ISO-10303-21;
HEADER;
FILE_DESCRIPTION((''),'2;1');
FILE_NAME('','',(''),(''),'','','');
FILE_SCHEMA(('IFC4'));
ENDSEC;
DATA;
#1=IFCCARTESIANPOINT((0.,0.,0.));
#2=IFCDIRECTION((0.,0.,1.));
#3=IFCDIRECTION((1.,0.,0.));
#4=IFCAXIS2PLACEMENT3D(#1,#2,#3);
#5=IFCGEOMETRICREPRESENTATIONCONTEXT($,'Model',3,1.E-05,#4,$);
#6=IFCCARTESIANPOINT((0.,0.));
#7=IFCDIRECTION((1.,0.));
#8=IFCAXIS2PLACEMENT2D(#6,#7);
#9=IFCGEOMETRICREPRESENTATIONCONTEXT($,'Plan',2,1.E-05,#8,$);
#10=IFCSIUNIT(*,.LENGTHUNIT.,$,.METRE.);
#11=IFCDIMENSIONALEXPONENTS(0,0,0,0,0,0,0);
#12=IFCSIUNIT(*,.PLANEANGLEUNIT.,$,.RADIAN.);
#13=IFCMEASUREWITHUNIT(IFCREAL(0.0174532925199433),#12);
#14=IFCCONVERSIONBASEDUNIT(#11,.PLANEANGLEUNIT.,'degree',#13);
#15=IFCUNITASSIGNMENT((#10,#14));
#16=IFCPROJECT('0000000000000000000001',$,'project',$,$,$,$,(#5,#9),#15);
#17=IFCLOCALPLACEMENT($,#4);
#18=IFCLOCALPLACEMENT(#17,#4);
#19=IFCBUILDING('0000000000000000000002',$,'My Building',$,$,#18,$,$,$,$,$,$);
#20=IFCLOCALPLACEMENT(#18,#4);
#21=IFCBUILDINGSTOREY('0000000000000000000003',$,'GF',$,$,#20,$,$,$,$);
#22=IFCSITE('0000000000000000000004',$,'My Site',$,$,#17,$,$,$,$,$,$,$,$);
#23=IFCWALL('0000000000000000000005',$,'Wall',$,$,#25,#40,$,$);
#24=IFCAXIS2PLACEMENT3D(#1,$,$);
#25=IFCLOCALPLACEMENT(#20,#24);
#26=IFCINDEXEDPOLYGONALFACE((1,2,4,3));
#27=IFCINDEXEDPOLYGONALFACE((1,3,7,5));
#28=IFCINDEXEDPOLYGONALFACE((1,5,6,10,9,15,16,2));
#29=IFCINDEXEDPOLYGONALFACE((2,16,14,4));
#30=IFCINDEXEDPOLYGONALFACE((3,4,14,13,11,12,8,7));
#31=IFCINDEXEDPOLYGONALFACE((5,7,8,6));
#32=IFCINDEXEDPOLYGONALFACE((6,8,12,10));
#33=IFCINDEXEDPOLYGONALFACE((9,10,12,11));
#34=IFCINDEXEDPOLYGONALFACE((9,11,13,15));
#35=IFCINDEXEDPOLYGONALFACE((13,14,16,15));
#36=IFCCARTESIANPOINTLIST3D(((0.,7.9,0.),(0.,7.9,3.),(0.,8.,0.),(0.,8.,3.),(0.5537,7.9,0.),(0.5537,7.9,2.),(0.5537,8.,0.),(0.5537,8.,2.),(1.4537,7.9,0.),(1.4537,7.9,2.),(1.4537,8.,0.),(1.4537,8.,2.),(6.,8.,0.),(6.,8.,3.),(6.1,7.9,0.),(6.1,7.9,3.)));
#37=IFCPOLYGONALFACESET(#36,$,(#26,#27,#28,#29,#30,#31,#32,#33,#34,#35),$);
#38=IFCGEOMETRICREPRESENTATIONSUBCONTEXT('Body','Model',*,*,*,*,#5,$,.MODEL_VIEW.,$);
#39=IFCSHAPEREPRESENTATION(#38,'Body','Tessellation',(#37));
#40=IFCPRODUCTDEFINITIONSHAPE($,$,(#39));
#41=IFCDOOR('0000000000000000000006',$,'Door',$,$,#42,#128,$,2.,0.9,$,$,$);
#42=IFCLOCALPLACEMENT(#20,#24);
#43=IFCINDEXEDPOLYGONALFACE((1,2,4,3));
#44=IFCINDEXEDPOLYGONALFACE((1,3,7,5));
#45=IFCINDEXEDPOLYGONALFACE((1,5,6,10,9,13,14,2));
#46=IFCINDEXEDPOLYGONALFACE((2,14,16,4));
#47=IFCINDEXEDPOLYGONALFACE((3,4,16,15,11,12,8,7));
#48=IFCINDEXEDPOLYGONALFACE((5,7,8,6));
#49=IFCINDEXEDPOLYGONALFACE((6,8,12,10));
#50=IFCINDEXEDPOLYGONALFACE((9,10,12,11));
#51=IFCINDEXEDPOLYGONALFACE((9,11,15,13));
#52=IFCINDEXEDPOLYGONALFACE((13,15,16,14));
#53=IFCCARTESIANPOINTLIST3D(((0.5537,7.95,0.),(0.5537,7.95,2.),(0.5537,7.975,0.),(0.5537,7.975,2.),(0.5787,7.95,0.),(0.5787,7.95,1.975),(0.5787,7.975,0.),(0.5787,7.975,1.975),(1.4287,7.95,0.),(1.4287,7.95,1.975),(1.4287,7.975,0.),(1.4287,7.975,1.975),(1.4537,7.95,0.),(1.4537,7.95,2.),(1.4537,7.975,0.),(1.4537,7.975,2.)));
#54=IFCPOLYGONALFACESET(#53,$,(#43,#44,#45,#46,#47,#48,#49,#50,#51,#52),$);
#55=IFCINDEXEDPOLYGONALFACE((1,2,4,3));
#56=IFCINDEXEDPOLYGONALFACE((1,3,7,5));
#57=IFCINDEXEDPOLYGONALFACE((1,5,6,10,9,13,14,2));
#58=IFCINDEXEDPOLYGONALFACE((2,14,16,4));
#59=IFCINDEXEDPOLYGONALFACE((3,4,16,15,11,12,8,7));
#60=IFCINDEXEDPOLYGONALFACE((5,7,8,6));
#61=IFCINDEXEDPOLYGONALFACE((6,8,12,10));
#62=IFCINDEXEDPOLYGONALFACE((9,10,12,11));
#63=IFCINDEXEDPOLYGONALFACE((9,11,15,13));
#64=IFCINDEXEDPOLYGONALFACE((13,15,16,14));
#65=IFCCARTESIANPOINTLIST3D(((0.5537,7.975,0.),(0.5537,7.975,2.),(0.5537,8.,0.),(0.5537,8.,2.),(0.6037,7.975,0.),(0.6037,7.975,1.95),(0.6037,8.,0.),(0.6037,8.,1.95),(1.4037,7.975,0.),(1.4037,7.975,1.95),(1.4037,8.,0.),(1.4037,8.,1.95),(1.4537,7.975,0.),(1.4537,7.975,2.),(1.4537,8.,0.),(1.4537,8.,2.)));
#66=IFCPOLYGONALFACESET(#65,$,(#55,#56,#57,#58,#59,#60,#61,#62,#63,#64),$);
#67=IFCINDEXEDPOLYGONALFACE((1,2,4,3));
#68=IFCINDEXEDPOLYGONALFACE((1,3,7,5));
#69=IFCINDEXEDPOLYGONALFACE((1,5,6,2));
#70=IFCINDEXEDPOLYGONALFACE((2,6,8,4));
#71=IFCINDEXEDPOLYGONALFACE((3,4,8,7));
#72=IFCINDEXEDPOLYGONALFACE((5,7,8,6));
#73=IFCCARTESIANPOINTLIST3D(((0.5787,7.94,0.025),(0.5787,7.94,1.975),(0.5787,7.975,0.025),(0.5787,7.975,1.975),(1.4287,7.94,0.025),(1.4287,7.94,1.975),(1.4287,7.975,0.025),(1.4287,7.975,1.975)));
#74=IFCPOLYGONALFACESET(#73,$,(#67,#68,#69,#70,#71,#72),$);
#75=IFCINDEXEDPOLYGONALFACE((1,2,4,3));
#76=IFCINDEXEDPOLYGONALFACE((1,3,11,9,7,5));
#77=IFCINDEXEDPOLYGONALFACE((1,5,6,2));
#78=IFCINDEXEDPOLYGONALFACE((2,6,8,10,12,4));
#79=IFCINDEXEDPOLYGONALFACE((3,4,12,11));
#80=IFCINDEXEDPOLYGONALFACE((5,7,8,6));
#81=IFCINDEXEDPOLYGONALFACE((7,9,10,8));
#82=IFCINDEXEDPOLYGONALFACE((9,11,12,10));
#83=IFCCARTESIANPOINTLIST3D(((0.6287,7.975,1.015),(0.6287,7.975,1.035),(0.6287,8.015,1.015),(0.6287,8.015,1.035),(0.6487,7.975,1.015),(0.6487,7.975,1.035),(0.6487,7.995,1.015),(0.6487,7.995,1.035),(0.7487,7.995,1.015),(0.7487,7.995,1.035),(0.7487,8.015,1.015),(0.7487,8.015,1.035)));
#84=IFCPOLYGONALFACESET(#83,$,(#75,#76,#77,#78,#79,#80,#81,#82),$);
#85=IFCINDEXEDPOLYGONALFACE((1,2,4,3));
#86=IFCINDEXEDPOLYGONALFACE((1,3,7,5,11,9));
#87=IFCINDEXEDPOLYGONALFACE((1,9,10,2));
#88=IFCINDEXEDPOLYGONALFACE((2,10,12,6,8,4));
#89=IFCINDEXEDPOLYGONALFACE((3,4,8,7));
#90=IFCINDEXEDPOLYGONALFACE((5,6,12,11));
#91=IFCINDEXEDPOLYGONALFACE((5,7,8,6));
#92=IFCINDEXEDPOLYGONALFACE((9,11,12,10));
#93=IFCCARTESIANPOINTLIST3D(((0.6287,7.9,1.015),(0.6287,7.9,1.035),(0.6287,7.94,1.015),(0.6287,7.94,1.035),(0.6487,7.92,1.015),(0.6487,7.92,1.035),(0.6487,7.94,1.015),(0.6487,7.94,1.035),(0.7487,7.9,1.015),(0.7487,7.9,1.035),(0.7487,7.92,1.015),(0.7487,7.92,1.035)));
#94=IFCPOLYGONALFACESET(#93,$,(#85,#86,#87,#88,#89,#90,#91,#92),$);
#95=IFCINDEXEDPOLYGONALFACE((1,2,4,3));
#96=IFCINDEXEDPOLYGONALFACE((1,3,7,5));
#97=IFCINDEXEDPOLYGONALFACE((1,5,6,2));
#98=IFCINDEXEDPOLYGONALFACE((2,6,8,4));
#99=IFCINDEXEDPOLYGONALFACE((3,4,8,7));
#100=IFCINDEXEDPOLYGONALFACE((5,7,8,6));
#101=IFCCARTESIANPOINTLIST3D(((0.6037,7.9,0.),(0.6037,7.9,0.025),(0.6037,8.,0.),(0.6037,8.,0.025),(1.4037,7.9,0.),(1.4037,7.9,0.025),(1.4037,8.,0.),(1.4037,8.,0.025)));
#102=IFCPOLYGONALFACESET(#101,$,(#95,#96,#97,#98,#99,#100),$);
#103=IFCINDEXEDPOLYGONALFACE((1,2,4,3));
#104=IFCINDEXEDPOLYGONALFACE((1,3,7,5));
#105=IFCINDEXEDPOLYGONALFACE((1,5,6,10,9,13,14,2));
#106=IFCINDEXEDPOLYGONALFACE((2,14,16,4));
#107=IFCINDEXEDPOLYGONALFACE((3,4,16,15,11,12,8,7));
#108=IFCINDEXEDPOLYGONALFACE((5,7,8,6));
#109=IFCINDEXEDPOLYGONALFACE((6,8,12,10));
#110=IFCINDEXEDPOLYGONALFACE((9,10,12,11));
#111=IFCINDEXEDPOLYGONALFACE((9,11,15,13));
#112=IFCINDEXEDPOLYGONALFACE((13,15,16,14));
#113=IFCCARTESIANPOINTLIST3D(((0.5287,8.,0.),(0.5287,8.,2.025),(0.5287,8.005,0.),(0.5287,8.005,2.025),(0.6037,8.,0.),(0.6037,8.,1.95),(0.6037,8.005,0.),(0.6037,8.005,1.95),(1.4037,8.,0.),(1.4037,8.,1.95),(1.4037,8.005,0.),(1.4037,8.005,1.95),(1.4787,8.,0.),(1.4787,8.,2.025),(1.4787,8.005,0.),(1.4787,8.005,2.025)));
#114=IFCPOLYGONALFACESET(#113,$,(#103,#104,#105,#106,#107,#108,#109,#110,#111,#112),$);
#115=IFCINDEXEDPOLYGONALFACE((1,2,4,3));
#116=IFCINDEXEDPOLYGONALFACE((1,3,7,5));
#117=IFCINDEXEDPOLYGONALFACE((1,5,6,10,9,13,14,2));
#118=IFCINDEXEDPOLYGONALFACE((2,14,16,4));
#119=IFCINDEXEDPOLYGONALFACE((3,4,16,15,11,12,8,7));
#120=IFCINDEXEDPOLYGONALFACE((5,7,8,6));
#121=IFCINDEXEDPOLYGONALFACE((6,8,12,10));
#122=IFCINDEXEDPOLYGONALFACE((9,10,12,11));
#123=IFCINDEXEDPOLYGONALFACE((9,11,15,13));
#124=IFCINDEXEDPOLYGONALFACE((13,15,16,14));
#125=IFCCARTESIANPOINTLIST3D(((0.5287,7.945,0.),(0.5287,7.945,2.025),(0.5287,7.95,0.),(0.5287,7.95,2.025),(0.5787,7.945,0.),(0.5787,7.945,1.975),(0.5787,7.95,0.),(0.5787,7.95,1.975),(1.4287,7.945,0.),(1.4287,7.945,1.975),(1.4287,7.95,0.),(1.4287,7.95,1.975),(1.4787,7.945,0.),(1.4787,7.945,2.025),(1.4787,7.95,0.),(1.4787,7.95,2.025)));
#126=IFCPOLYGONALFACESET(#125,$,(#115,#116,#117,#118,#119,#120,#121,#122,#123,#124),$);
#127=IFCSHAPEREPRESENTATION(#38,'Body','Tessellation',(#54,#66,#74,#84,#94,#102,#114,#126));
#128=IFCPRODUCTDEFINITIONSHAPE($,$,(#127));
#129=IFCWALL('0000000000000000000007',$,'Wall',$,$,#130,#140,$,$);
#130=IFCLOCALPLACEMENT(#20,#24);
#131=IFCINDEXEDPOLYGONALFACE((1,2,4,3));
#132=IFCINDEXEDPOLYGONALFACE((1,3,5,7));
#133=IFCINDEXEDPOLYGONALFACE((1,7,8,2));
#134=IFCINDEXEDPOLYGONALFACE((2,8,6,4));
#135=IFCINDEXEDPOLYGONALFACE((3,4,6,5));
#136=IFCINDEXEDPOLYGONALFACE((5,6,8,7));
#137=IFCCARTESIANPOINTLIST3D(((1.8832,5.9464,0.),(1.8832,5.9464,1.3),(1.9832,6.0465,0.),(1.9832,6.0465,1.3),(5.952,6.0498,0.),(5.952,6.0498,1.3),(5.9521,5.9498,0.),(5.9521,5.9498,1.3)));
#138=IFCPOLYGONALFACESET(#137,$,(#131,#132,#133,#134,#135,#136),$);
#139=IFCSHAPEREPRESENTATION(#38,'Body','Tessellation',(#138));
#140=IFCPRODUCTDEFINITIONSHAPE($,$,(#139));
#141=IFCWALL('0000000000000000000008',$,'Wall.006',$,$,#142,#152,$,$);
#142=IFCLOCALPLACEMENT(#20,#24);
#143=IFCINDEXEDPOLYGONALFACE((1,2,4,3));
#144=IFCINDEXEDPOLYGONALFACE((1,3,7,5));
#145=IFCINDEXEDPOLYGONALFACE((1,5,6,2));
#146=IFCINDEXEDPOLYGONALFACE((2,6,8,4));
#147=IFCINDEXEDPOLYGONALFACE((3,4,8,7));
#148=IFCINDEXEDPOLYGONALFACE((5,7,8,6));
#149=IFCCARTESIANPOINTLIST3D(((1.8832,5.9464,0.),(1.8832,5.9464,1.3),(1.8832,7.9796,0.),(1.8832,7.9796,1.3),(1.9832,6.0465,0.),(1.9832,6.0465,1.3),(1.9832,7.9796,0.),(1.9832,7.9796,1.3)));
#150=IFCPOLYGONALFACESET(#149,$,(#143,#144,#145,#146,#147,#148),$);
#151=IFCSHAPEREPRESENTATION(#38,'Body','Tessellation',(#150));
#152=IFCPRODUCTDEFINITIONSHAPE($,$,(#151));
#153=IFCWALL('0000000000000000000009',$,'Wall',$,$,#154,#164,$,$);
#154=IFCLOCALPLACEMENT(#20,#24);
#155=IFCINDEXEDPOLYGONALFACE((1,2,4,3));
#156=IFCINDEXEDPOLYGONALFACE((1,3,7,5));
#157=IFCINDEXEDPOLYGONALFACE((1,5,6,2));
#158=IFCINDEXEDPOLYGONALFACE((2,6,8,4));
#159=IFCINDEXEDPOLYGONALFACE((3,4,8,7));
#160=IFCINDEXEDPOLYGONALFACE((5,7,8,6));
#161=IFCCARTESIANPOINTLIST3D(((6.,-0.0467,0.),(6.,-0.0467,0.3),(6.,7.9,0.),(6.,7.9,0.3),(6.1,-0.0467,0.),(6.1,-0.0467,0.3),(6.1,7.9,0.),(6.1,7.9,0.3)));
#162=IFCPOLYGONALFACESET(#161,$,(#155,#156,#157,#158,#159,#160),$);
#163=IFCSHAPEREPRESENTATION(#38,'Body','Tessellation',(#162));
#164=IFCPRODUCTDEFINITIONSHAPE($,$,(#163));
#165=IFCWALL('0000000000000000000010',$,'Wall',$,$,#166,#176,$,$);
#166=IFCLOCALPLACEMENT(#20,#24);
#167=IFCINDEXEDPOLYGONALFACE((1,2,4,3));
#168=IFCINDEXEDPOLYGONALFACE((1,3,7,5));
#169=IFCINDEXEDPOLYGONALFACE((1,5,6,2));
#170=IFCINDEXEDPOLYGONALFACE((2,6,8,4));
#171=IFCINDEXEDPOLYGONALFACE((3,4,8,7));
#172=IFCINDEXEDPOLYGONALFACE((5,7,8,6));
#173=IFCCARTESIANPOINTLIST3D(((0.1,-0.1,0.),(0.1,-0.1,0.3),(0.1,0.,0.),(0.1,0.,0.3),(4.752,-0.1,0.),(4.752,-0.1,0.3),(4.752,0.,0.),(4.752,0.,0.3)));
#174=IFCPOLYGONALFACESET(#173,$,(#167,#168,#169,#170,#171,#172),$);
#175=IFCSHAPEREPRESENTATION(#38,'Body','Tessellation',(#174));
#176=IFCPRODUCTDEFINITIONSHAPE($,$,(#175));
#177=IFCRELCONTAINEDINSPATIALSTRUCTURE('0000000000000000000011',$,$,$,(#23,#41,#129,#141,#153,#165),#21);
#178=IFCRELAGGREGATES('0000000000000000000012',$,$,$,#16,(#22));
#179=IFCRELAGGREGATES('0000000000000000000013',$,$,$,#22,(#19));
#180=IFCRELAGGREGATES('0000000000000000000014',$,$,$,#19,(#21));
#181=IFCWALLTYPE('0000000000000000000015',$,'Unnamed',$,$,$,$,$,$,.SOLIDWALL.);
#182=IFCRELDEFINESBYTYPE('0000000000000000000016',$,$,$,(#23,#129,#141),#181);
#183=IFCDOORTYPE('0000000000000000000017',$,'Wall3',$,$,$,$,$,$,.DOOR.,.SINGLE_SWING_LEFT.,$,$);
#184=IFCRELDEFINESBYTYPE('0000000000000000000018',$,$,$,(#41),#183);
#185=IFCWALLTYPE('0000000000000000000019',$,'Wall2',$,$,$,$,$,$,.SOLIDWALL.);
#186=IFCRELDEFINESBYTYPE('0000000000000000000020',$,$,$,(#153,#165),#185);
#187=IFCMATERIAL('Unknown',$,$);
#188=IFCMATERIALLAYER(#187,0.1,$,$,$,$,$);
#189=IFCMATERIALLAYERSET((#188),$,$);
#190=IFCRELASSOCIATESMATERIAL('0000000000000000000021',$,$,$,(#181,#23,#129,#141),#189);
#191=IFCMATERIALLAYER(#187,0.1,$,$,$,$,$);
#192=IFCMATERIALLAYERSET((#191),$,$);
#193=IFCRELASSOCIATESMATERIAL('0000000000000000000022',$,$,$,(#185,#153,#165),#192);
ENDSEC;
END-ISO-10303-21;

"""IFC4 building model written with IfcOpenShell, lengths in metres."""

from ifc_helpers import new_model, entity, si_unit, converted_unit, frame, origin_with_axes, origin_2d_with_axis, place, context, subcontext, project, spatial, line, indexed_curve, outline, extrude, shape, source, transform, mapped, material, layer, layer_set, layer_usage, type_object, type_shapes, element, fill, save


model = new_model("IFC4")

# Units and contexts
model_context = context("Model", 3, precision=1e-05, world=origin_with_axes())
plan_context = context("Plan", 2, precision=1e-05, world=origin_2d_with_axis())
body_context_1 = subcontext(model_context, "Body", "Model", "MODEL_VIEW")
body_context_2 = subcontext(plan_context, "Body", "Plan", "PLAN_VIEW")
ifc_project = project(units=[si_unit("LENGTHUNIT", "METRE"), converted_unit("PLANEANGLEUNIT", "degree", entity("IfcReal", 0.0174532925199433), si_unit("PLANEANGLEUNIT", "RADIAN"), dimensions=[0, 0, 0, 0, 0, 0, 0])], contexts=[model_context, plan_context])

# Site, building, storey
site_placement = place(None, origin_with_axes())
site = spatial("IfcSite", under=ifc_project, at=site_placement, Name="My Site")
building_placement = place(site_placement, origin_with_axes())
building = spatial("IfcBuilding", under=site, at=building_placement, Name="My Building")
storey_placement = place(building_placement, origin_with_axes())
storey = spatial("IfcBuildingStorey", under=building, at=storey_placement, Name="GF")

# Shared definitions
ifc_material = material(Name="Unknown")

# Shared definitions
ifc_layer_1 = layer(ifc_material, 0.1)
ifc_layer_set_1 = layer_set([ifc_layer_1])
wall_type_1 = type_object("IfcWallType", Name="Unnamed", PredefinedType="SOLIDWALL", material=ifc_layer_set_1)

# Wall, opening, door
ifc_layer_usage_1 = layer_usage(ifc_layer_set_1, "AXIS2", "POSITIVE", 0.0)
wall_1_placement = place(storey_placement, frame((6.0, 8.0, 0.0), z_axis=(0.0, 0.0, 1.0), x_axis=(-1.0, 0.0, 0.0)))
wall_1 = element("IfcWall", 1, at=wall_1_placement, inside=storey, type_object=wall_type_1, material=ifc_layer_usage_1, Name="Wall", context=body_context_1, shape_type="SweptSolid", body=[
    extrude(outline(indexed_curve([(0.0, 0.0), (-0.1, 0.1), (6.0, 0.1), (6.0, 0.0)], segments=[line(1, 2, 3, 4, 1)])), origin_with_axes(), (0.0, 0.0, 1.0), 3.0),
])
shared_shape_1 = source(origin_with_axes(), body_context_1, "Body", "SweptSolid", [
    extrude(outline(indexed_curve([(0.0, 0.0), (0.9, 0.0), (0.9, 2.0), (0.0, 2.0)], segments=[line(1, 2, 3, 4, 1)])), frame((0.0, -0.6, 0.0), z_axis=(0.0, -1.0, 0.0), x_axis=(1.0, 0.0, 0.0)), (0.0, 0.0, -1.0), 1.2),
])
opening_1_placement = place(wall_1_placement, frame((4.5463, 0.0, 0.0), z_axis=(0.0, 0.0, 1.0), x_axis=(1.0, 0.0, 0.0)))
opening_1 = element("IfcOpeningElement", 2, at=opening_1_placement, cuts=wall_1, PredefinedType="OPENING", context=body_context_1, shape_type="MappedRepresentation", body=[
    mapped(shared_shape_1, transform((0.0, 0.0, 0.0), x_axis=(1.0, 0.0, 0.0), y_axis=(0.0, 1.0, 0.0), z_axis=(0.0, 0.0, 1.0), scale=1.0)),
])
door_type = type_object("IfcDoorType", Name="Wall3", OperationType="SINGLE_SWING_LEFT", PredefinedType="DOOR")
shared_shape_2 = source(origin_with_axes(), body_context_1, "Body", "SweptSolid", [
    extrude(outline(indexed_curve([(0.0, 0.0), (0.0, 2.0), (0.9, 2.0), (0.9, 0.0), (0.875, 0.0), (0.875, 1.975), (0.025, 1.975), (0.025, 0.0)], segments=[line(1, 2, 3, 4, 5, 6, 7, 8, 1)])), frame((0.0, 0.025, 0.0), z_axis=(0.0, -1.0, 0.0), x_axis=(1.0, 0.0, 0.0)), (0.0, 0.0, -1.0), 0.025),
    extrude(outline(indexed_curve([(0.0, 0.0), (0.0, 2.0), (0.9, 2.0), (0.9, 0.0), (0.85, 0.0), (0.85, 1.95), (0.05, 1.95), (0.05, 0.0)], segments=[line(1, 2, 3, 4, 5, 6, 7, 8, 1)])), frame((0.0, 0.0, 0.0), z_axis=(0.0, -1.0, 0.0), x_axis=(1.0, 0.0, 0.0)), (0.0, 0.0, -1.0), 0.025),
    extrude(outline(indexed_curve([(0.0, 0.0), (0.85, 0.0), (0.85, 0.035), (0.0, 0.035)], segments=[line(1, 2, 3, 4, 1)])), frame((0.025, 0.025, 0.025), z_axis=(0.0, 0.0, 1.0), x_axis=(1.0, 0.0, 0.0)), (0.0, 0.0, 1.0), 1.95),
    extrude(outline(indexed_curve([(0.0, 0.0), (0.0, -0.04), (-0.12, -0.04), (-0.12, -0.02), (-0.02, -0.02), (-0.02, 0.0)], segments=[line(1, 2, 3, 4, 5, 6, 1)])), frame((0.825, 0.025, 1.015), z_axis=(0.0, 0.0, 1.0), x_axis=(1.0, 0.0, 0.0)), (0.0, 0.0, 1.0), 0.02),
    extrude(outline(indexed_curve([(0.0, 0.0), (0.0, 0.04), (-0.12, 0.04), (-0.12, 0.02), (-0.02, 0.02), (-0.02, 0.0)], segments=[line(1, 2, 3, 4, 5, 6, 1)])), frame((0.825, 0.06, 1.015), z_axis=(0.0, 0.0, 1.0), x_axis=(1.0, 0.0, 0.0)), (0.0, 0.0, 1.0), 0.02),
    extrude(outline(indexed_curve([(0.0, 0.0), (0.8, 0.0), (0.8, 0.1), (0.0, 0.1)], segments=[line(1, 2, 3, 4, 1)])), frame((0.05, 0.0, 0.0), z_axis=(0.0, 0.0, 1.0), x_axis=(1.0, 0.0, 0.0)), (0.0, 0.0, 1.0), 0.025),
    extrude(outline(indexed_curve([(0.0, 0.0), (0.0, 2.025), (0.95, 2.025), (0.95, 0.0), (0.875, 0.0), (0.875, 1.95), (0.075, 1.95), (0.075, 0.0)], segments=[line(1, 2, 3, 4, 5, 6, 7, 8, 1)])), frame((-0.025, -0.005, 0.0), z_axis=(0.0, -1.0, 0.0), x_axis=(1.0, 0.0, 0.0)), (0.0, 0.0, -1.0), 0.005),
    extrude(outline(indexed_curve([(0.0, 0.0), (0.0, 2.025), (0.95, 2.025), (0.95, 0.0), (0.9, 0.0), (0.9, 1.975), (0.05, 1.975), (0.05, 0.0)], segments=[line(1, 2, 3, 4, 5, 6, 7, 8, 1)])), frame((-0.025, 0.05, 0.0), z_axis=(0.0, -1.0, 0.0), x_axis=(1.0, 0.0, 0.0)), (0.0, 0.0, -1.0), 0.005),
])
shared_shape_3 = source(origin_with_axes(), body_context_2, "Body", "Curve2D", [
    entity("IfcIndexedPolyCurve", entity("IfcCartesianPointList2D", [[0.0, 0.0], [0.0, 0.05], [0.025, 0.05], [0.025, 0.025], [0.05, 0.025], [0.05, 0.0]]), [entity("IfcLineIndex", [1, 2, 3, 4, 5, 6, 1])]),
    entity("IfcIndexedPolyCurve", entity("IfcCartesianPointList2D", [[0.9, 0.0], [0.9, 0.05], [0.875, 0.05], [0.875, 0.025], [0.85, 0.025], [0.85, 0.0]]), [entity("IfcLineIndex", [1, 2, 3, 4, 5, 6, 1])]),
    entity("IfcTrimmedCurve", entity("IfcEllipse", entity("IfcAxis2Placement2D", entity("IfcCartesianPoint", [0.06, 0.05]), entity("IfcDirection", [1.0, 0.0])), 0.815, 0.85), [entity("IfcCartesianPoint", [0.875, 0.05])], [entity("IfcCartesianPoint", [0.06, 0.9])], True, "CARTESIAN"),
    entity("IfcIndexedPolyCurve", entity("IfcCartesianPointList2D", [[0.025, 0.05], [0.06, 0.05], [0.06, 0.9], [0.025, 0.9]]), [entity("IfcLineIndex", [1, 2, 3, 4, 1])]),
])
type_shapes(door_type, [shared_shape_2, shared_shape_3])
door_placement = place(opening_1_placement, frame((0.0, 0.0, 0.0), z_axis=(0.0, 0.0, 1.0), x_axis=(1.0, 0.0, 0.0)))
door = element("IfcDoor", 3, at=door_placement, inside=storey, type_object=door_type, Name="Door", OverallHeight=2.0, OverallWidth=0.9, shapes=[
    shape(body_context_1, "Body", "MappedRepresentation", [mapped(shared_shape_2, transform((0.0, 0.0, 0.0), x_axis=(1.0, 0.0, 0.0), y_axis=(0.0, 1.0, 0.0), z_axis=(0.0, 0.0, 1.0), scale=1.0))]),
    shape(body_context_2, "Body", "MappedRepresentation", [mapped(shared_shape_3, transform((0.0, 0.0, 0.0), x_axis=(1.0, 0.0, 0.0), y_axis=(0.0, 1.0, 0.0), z_axis=(0.0, 0.0, 1.0), scale=1.0))]),
])
fill(opening_1, door)

# Walls
ifc_layer_usage_2 = layer_usage(ifc_layer_set_1, "AXIS2", "POSITIVE", 0.0)
wall_2_placement = place(storey_placement, frame((5.952, 6.0498, 0.0), z_axis=(0.0, 0.0, 1.0), x_axis=(-1.0, -0.000833, 0.0)))
element("IfcWall", 4, at=wall_2_placement, inside=storey, type_object=wall_type_1, material=ifc_layer_usage_2, Name="Wall", context=body_context_1, shape_type="SweptSolid", body=[
    extrude(outline(indexed_curve([(0.0, 0.0), (0.0, 0.1), (4.0689, 0.1), (3.9688, 0.0)], segments=[line(1, 2, 3, 4, 1)])), origin_with_axes(), (0.0, 0.0, 1.0), 1.3),
])
ifc_layer_usage_3 = layer_usage(ifc_layer_set_1, "AXIS2", "POSITIVE", 0.0)
wall_3_placement = place(storey_placement, frame((1.9832, 6.0465, 0.0), z_axis=(0.0, 0.0, 1.0), x_axis=(0.0, 1.0, 0.0)))
element("IfcWall", 5, at=wall_3_placement, inside=storey, type_object=wall_type_1, material=ifc_layer_usage_3, Name="Wall.006", context=body_context_1, shape_type="SweptSolid", body=[
    extrude(outline(indexed_curve([(0.0, 0.0), (-0.1001, 0.1), (1.9331, 0.1), (1.9331, 0.0)], segments=[line(1, 2, 3, 4, 1)])), origin_with_axes(), (0.0, 0.0, 1.0), 1.3),
])
ifc_layer_2 = layer(ifc_material, 0.1)
ifc_layer_set_2 = layer_set([ifc_layer_2])
ifc_layer_usage_4 = layer_usage(ifc_layer_set_2, "AXIS2", "POSITIVE", 0.0)
wall_type_2 = type_object("IfcWallType", Name="Wall2", PredefinedType="SOLIDWALL", material=ifc_layer_set_2)
wall_4_placement = place(storey_placement, frame((6.0, 7.9, 0.0), z_axis=(0.0, 0.0, 1.0), x_axis=(0.0, -1.0, 0.0)))
element("IfcWall", 6, at=wall_4_placement, inside=storey, type_object=wall_type_2, material=ifc_layer_usage_4, Name="Wall", context=body_context_1, shape_type="SweptSolid", body=[
    extrude(outline(indexed_curve([(0.0, 0.0), (0.0, 0.1), (7.9467, 0.1), (7.9467, 0.0)], segments=[line(1, 2, 3, 4, 1)])), origin_with_axes(), (0.0, 0.0, 1.0), 0.3),
])
ifc_layer_usage_5 = layer_usage(ifc_layer_set_2, "AXIS2", "POSITIVE", 0.0)
wall_5_placement = place(storey_placement, frame((0.1, -0.1, 0.0), z_axis=(0.0, 0.0, 1.0), x_axis=(1.0, 0.0, 0.0)))
element("IfcWall", 7, at=wall_5_placement, inside=storey, type_object=wall_type_2, material=ifc_layer_usage_5, Name="Wall", context=body_context_1, shape_type="SweptSolid", body=[
    extrude(outline(indexed_curve([(0.0, 0.0), (0.0, 0.1), (4.652, 0.1), (4.652, 0.0)], segments=[line(1, 2, 3, 4, 1)])), origin_with_axes(), (0.0, 0.0, 1.0), 0.3),
])

save(model, "model.ifc")
